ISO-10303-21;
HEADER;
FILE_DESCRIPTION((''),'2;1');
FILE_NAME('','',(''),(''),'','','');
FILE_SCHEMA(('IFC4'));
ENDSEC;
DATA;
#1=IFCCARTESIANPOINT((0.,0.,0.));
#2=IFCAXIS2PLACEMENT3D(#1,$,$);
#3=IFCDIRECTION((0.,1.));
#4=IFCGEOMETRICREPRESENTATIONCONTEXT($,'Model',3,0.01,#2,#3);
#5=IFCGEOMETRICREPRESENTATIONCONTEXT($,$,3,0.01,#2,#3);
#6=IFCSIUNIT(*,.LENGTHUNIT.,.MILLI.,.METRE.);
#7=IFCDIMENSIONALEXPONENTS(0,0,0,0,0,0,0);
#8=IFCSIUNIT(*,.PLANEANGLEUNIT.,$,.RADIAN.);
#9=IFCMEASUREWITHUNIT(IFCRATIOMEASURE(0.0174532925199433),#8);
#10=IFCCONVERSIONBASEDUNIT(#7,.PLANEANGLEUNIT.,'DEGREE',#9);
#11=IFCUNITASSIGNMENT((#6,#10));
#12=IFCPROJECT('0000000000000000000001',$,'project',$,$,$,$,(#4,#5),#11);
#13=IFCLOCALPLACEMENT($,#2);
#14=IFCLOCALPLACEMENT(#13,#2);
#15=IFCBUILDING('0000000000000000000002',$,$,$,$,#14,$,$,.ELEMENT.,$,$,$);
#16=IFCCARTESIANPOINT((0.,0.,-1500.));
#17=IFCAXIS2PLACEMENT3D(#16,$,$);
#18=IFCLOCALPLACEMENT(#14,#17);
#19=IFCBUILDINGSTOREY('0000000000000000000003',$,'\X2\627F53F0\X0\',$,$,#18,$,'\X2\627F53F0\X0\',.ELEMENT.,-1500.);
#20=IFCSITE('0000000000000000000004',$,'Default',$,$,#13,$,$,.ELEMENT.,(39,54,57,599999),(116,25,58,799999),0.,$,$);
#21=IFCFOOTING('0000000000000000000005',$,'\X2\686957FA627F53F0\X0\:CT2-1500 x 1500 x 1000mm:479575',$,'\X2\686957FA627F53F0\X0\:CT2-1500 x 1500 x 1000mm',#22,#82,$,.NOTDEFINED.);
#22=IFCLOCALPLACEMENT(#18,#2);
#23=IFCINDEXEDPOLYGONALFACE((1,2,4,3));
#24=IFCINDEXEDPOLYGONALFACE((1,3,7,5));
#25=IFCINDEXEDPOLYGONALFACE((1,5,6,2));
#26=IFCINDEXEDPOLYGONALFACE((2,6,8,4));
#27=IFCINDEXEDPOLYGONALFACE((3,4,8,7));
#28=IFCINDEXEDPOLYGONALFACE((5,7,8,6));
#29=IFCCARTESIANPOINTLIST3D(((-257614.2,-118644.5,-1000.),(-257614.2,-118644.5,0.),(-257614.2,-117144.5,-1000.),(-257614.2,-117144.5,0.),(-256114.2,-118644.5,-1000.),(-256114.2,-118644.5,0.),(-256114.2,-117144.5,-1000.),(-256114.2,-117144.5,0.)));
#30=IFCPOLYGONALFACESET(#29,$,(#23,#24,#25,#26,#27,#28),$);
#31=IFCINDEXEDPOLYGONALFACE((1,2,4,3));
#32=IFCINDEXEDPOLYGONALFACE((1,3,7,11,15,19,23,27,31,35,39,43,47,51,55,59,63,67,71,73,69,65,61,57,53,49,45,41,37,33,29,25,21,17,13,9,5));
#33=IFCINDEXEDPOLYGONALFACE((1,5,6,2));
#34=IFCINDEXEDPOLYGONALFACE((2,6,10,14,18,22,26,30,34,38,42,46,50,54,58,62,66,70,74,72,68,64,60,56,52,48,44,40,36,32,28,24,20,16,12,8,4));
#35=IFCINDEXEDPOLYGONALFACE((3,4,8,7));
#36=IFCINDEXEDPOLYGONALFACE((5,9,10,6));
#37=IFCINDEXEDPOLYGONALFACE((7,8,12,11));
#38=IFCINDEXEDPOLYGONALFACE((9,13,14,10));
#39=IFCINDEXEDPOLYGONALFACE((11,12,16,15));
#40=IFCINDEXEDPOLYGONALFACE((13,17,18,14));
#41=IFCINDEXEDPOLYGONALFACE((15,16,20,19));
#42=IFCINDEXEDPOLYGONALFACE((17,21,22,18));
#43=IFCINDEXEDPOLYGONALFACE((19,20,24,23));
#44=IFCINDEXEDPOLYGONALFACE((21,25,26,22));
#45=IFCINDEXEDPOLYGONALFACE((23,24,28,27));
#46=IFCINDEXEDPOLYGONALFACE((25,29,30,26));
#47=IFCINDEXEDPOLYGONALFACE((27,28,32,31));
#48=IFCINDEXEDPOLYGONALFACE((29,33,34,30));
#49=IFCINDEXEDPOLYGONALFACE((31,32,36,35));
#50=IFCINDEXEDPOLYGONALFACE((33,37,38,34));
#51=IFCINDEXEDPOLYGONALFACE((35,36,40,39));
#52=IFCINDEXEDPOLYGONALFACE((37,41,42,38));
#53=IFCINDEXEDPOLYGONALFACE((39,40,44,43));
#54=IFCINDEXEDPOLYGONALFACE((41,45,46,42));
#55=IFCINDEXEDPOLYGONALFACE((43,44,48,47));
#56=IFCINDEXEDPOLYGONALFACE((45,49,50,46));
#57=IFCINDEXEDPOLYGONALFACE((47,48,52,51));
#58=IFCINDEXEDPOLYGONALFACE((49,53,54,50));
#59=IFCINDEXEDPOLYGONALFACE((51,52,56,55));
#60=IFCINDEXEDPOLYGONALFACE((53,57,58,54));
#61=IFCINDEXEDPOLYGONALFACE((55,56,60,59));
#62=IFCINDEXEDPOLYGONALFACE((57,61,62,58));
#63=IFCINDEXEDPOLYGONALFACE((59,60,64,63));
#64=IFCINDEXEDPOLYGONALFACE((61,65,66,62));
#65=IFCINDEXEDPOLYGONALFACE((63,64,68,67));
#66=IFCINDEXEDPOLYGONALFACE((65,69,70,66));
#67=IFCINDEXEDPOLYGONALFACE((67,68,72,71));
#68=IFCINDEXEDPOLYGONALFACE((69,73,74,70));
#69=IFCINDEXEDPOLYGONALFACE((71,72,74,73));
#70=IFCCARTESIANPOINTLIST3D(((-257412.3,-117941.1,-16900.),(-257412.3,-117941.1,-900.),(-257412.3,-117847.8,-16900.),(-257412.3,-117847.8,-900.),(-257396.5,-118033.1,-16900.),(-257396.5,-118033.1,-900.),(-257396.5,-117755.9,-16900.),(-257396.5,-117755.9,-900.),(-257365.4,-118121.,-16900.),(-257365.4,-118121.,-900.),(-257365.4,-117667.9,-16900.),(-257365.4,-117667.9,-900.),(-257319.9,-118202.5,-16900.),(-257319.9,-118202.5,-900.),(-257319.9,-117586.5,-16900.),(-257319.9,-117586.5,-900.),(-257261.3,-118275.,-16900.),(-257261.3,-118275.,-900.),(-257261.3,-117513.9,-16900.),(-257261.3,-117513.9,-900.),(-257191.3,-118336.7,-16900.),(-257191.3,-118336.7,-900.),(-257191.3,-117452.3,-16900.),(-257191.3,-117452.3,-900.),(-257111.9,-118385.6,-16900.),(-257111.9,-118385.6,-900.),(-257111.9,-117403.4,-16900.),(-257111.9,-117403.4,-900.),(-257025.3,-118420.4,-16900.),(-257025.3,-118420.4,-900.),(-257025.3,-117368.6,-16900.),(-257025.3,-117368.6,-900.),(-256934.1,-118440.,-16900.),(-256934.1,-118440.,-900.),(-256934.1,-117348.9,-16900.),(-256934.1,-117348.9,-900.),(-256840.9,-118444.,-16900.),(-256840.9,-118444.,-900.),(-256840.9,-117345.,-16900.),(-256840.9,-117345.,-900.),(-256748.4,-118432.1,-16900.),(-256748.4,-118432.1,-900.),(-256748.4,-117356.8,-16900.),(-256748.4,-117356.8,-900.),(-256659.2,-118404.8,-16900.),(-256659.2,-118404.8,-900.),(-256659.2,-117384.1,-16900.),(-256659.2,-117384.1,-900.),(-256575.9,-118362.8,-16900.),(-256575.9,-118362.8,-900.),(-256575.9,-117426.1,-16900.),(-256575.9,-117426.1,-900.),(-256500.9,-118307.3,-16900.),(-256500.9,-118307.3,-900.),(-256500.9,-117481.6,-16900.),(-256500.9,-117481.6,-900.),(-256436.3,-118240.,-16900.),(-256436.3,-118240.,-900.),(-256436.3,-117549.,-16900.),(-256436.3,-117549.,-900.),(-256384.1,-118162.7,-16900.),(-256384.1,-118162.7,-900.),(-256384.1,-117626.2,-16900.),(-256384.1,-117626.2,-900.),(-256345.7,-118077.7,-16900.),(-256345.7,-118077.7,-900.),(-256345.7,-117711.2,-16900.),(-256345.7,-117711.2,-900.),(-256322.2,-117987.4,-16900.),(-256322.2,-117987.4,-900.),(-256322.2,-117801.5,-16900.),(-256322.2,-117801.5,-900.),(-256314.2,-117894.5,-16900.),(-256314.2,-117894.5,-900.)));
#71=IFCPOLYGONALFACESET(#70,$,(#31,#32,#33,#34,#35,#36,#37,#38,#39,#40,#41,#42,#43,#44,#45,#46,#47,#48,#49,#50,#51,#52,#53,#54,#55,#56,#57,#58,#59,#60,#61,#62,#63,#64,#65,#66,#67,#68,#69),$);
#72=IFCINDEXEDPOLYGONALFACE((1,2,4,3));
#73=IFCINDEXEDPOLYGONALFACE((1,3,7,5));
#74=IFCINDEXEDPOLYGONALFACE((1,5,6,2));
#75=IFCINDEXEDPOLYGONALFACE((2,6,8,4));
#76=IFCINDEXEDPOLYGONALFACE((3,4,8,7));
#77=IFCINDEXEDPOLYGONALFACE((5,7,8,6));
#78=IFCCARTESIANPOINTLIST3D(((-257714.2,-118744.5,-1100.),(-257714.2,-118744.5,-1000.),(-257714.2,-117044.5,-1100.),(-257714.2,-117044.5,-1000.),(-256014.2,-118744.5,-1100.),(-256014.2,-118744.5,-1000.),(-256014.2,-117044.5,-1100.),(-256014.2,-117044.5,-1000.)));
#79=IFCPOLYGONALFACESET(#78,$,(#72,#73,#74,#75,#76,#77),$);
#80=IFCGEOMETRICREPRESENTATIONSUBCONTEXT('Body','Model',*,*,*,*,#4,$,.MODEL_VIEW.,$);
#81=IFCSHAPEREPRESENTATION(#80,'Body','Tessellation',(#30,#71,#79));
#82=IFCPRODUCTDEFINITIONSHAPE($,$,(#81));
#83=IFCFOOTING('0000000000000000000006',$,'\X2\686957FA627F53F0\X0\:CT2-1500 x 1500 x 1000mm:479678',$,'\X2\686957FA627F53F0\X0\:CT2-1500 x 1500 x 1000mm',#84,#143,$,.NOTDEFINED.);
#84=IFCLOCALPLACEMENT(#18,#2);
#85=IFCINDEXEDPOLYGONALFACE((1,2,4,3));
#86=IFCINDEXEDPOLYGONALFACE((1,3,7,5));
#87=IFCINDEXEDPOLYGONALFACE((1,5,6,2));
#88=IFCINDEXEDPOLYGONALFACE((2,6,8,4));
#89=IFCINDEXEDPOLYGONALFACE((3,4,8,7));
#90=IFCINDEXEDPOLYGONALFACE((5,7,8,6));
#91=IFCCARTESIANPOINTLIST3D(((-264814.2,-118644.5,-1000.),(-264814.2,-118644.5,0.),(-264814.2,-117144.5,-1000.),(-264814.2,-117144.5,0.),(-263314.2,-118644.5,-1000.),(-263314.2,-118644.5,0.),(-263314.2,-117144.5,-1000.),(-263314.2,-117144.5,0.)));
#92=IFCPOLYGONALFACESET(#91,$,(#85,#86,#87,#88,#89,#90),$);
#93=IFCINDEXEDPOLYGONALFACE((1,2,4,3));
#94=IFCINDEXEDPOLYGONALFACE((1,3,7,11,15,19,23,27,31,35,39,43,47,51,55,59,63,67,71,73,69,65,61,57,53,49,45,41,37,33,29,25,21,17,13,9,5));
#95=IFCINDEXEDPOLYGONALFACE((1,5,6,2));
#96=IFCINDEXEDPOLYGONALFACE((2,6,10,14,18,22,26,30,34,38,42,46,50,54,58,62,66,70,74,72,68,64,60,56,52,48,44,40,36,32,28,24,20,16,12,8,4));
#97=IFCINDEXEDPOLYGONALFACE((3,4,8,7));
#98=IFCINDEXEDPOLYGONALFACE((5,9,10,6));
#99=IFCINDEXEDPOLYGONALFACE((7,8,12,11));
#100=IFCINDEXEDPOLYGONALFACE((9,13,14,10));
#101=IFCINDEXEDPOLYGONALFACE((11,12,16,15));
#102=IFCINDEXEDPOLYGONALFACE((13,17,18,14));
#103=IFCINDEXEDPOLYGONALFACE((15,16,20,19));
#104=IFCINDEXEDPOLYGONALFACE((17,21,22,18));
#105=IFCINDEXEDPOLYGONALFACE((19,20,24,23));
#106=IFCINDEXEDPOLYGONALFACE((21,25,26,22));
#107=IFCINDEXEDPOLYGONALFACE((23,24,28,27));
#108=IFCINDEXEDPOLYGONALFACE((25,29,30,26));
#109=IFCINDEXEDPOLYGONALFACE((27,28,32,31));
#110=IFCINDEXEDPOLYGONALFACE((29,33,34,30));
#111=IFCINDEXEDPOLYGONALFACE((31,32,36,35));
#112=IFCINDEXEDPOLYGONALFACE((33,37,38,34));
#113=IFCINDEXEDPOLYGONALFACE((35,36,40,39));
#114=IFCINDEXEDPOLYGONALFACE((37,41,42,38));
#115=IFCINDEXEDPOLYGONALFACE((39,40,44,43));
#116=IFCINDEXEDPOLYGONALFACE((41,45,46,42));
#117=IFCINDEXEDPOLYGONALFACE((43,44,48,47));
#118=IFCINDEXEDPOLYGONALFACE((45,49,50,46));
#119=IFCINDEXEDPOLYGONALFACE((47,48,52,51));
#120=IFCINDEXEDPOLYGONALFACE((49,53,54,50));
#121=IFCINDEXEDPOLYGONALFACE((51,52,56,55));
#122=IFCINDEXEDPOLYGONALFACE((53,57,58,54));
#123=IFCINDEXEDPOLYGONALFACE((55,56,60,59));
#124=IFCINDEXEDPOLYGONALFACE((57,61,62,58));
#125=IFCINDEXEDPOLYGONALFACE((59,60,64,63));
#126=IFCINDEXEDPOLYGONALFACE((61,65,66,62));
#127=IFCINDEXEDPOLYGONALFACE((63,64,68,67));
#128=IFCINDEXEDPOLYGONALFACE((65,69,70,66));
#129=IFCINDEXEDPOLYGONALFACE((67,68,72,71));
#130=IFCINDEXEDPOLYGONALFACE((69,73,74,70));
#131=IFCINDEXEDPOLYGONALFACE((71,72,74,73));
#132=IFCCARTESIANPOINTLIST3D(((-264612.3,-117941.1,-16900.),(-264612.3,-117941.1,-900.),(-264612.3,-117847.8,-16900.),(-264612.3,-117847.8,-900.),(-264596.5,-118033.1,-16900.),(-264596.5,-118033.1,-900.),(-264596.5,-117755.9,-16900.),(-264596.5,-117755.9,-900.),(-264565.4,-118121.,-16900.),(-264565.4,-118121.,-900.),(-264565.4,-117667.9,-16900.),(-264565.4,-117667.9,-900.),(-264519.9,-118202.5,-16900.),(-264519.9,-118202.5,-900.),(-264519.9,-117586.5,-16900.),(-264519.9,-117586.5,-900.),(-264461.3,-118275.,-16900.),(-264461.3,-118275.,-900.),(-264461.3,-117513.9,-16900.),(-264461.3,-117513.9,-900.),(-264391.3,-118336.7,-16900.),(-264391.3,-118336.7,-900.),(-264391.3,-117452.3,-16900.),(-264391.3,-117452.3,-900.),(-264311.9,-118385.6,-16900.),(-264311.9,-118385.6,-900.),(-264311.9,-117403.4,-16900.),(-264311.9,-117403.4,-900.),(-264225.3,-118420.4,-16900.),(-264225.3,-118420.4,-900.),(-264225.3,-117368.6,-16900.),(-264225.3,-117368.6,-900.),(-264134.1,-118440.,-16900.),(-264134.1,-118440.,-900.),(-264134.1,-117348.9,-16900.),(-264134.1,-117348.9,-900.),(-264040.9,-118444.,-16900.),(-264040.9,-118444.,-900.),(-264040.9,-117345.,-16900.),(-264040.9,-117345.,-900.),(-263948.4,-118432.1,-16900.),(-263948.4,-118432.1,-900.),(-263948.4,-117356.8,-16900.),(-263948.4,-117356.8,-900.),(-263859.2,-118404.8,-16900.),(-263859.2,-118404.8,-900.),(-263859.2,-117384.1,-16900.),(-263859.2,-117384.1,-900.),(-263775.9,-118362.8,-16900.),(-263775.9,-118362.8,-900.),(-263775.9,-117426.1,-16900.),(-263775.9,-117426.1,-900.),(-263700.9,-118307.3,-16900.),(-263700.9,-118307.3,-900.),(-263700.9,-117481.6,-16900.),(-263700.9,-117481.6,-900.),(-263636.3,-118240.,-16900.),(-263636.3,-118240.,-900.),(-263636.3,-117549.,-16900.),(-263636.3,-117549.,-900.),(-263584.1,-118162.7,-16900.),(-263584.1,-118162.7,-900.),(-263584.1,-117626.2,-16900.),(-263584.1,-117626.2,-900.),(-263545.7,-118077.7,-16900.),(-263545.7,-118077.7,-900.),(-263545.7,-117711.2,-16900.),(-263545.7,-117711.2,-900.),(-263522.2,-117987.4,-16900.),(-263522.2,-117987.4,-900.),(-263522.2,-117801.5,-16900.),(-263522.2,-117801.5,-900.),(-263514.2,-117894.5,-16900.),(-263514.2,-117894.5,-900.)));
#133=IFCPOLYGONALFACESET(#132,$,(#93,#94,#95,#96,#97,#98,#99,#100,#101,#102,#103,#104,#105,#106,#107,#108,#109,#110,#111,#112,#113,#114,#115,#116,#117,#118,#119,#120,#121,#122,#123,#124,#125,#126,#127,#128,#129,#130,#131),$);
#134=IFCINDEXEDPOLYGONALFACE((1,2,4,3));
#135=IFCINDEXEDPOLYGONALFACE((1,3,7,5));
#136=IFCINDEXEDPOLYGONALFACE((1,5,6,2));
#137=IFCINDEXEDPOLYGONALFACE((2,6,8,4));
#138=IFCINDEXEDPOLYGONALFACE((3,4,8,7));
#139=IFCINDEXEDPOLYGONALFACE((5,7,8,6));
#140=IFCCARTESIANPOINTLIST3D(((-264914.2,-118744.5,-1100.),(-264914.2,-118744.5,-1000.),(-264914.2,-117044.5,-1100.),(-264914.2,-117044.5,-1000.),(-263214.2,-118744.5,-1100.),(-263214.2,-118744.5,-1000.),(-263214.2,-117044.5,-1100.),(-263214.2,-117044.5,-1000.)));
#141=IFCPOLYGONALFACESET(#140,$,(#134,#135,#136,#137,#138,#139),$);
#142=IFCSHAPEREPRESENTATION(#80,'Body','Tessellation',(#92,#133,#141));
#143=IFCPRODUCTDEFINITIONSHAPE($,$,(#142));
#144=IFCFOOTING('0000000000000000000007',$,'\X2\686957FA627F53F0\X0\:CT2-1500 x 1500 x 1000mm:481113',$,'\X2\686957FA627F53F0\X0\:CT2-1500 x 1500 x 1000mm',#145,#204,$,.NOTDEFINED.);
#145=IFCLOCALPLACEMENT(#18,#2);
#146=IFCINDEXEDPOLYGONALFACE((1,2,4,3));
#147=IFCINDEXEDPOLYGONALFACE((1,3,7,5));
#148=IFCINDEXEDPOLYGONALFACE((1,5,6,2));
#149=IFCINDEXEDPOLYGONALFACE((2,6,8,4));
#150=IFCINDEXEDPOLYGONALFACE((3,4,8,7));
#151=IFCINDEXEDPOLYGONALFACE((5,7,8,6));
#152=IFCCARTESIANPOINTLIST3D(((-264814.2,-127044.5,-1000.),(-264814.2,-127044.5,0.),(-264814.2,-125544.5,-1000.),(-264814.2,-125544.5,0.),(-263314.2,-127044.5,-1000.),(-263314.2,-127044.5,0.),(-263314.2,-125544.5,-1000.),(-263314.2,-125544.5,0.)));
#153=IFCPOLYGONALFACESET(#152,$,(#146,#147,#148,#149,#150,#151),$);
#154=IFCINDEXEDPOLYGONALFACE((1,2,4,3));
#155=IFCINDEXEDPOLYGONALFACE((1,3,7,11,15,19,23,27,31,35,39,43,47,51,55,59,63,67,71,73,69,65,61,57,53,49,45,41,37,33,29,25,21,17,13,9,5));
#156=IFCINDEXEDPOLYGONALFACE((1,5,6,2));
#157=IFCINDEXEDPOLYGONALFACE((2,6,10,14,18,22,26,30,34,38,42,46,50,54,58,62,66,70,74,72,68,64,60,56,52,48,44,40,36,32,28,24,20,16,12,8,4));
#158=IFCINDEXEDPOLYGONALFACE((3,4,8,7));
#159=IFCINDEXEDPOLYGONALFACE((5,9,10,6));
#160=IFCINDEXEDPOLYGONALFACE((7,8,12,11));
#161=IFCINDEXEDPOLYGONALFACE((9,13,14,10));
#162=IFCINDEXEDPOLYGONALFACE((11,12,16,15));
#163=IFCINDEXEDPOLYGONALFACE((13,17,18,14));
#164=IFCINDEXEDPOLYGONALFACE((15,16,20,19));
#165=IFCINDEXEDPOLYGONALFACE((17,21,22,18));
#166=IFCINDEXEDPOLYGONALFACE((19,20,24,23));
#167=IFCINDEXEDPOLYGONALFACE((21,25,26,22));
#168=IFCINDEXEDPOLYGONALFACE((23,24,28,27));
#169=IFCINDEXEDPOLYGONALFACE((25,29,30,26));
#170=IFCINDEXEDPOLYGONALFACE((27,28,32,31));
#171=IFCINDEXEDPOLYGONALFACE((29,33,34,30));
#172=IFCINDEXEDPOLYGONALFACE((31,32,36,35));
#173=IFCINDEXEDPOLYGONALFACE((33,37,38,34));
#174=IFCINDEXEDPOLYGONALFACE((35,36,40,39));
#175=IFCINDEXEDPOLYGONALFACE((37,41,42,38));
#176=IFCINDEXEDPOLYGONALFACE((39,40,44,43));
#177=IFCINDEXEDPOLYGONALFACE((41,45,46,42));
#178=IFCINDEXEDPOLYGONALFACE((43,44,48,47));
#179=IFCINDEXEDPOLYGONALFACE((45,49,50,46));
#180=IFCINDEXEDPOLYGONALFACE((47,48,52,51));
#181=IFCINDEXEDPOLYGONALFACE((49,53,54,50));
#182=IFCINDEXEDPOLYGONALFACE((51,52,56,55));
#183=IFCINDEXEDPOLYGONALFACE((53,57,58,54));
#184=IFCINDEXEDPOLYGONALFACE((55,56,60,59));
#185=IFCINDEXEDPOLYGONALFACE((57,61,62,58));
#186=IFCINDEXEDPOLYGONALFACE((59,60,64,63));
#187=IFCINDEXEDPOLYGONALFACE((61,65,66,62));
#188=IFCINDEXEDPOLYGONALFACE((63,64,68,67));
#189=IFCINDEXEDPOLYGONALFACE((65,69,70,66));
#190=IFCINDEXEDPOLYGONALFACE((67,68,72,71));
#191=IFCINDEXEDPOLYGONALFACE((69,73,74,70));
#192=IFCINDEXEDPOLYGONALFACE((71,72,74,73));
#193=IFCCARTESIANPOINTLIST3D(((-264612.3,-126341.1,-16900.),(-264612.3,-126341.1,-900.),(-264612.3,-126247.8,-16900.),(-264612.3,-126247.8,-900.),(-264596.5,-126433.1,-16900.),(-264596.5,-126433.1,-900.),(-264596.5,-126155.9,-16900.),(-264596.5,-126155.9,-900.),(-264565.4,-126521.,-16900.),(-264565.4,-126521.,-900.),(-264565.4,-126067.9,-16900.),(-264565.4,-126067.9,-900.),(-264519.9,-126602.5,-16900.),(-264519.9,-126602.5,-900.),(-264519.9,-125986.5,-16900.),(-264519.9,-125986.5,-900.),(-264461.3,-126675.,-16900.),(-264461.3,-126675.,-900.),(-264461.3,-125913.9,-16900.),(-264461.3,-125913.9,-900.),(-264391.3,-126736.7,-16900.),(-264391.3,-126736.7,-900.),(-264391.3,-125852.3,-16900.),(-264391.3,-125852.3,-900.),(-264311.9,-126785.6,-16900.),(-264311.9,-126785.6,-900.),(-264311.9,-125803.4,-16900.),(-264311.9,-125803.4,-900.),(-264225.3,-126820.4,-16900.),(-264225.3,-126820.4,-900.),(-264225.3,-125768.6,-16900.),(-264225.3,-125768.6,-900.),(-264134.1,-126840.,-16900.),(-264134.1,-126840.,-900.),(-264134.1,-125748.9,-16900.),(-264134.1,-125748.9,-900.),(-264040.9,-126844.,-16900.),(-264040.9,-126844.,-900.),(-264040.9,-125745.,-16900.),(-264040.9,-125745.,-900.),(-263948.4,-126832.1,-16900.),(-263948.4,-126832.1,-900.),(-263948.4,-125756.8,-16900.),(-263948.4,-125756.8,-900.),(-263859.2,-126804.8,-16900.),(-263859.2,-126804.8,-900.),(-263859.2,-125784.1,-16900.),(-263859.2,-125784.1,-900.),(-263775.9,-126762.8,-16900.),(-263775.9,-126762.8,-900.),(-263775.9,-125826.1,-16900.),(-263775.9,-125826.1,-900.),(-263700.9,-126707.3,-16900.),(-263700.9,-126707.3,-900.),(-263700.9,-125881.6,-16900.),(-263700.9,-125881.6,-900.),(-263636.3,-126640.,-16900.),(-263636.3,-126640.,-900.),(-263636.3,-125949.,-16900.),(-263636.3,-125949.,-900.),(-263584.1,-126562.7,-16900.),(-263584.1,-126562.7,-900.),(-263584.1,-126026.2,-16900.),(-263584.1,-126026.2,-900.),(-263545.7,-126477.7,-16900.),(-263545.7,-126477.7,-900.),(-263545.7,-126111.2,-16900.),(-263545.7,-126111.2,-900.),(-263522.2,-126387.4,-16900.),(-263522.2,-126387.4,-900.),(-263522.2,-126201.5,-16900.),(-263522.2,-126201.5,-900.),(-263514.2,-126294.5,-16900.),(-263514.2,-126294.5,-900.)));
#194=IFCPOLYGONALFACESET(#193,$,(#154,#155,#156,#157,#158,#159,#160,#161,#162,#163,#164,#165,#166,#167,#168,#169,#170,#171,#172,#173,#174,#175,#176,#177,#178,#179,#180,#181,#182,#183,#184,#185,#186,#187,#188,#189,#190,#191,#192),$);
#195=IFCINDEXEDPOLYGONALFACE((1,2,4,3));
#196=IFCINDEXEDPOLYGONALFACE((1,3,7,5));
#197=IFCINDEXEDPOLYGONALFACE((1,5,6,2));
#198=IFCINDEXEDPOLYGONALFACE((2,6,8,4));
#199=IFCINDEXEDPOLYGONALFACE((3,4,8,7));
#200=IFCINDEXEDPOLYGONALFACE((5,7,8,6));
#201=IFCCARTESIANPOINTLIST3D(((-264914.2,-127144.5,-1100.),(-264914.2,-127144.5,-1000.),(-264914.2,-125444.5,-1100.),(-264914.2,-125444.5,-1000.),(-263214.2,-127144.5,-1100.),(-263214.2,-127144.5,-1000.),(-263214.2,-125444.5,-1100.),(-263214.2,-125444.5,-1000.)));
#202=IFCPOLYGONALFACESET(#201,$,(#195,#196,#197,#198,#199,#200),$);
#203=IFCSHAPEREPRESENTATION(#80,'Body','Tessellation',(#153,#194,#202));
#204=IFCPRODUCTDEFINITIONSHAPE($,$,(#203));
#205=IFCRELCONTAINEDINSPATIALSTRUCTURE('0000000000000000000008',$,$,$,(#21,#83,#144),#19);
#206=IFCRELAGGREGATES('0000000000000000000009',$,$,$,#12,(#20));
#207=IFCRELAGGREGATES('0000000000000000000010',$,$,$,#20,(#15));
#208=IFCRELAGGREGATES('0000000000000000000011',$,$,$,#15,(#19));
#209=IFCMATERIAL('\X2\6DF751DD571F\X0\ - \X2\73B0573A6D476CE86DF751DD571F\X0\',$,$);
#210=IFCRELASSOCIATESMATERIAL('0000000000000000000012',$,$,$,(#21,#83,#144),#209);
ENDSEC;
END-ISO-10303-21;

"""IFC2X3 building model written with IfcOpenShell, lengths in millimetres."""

from ifc_helpers import new_model, entity, si_unit, converted_unit, direction, frame, frame_2d, origin, origin_2d_with_axis, place, context, subcontext, project, spatial, rectangle, circle, extrude, material, element, save


model = new_model("IFC2X3")

# Units and contexts
model_context = context("Model", 3, precision=0.01, world=origin(), true_north=direction((0.0, 1.0)))
context_of_model = context(None, 3, precision=0.01, world=origin(), true_north=direction((0.0, 1.0)))
body_context = subcontext(model_context, "Body", "Model", "MODEL_VIEW")
ifc_project = project(units=[si_unit("LENGTHUNIT", "METRE", prefix="MILLI"), converted_unit("PLANEANGLEUNIT", "DEGREE", entity("IfcRatioMeasure", 0.0174532925199433), si_unit("PLANEANGLEUNIT", "RADIAN"), dimensions=[0, 0, 0, 0, 0, 0, 0])], contexts=[model_context, context_of_model])

# Site, building, storey
site_placement = place(None, origin())
site = spatial("IfcSite", under=ifc_project, at=site_placement, Name="Default", CompositionType="ELEMENT", RefLatitude=(39, 54, 57, 599999), RefLongitude=(116, 25, 58, 799999), RefElevation=0.0)
building_placement = place(site_placement, origin())
building = spatial("IfcBuilding", under=site, at=building_placement, CompositionType="ELEMENT")
storey_placement = place(building_placement, frame((0.0, 0.0, -1500.0)))
storey = spatial("IfcBuildingStorey", under=building, at=storey_placement, Name="承台", LongName="承台", CompositionType="ELEMENT", Elevation=-1500.0)

# Footings
ifc_material_1 = material(Name="混凝土 - 现场浇注混凝土")
footing_1_placement = place(storey_placement, frame((-257714.2, -118744.5, -16900.0)))
element("IfcFooting", 1, at=footing_1_placement, inside=storey, material=ifc_material_1, Name="桩基承台:CT2-1500 x 1500 x 1000mm:479575", ObjectType="桩基承台:CT2-1500 x 1500 x 1000mm", PredefinedType="NOTDEFINED", context=body_context, shape_type="SweptSolid", body=[
    extrude(rectangle(XDim=1500.0, YDim=1500.0, at=origin_2d_with_axis()), frame((850.0, 850.0, 15900.0), z_axis=(0.0, 0.0, 1.0), x_axis=(-1.0, 0.0, 0.0)), (0.0, 0.0, 1.0), 1000.0),
    extrude(circle(Radius=550.0, at=origin_2d_with_axis()), frame((850.0, 850.0, 0.0)), (0.0, 0.0, 1.0), 16000.0),
    extrude(rectangle(XDim=1700.0, YDim=1700.0, at=frame_2d((0.0, 0.0), x_axis=(1.0, 0.0))), frame((850.0, 850.0, 15800.0), z_axis=(0.0, 0.0, 1.0), x_axis=(0.0, 1.0, 0.0)), (0.0, 0.0, 1.0), 100.0),
])
footing_2_placement = place(storey_placement, frame((-264914.2, -118744.5, -16900.0)))
element("IfcFooting", 2, at=footing_2_placement, inside=storey, material=ifc_material_1, Name="桩基承台:CT2-1500 x 1500 x 1000mm:479678", ObjectType="桩基承台:CT2-1500 x 1500 x 1000mm", PredefinedType="NOTDEFINED", context=body_context, shape_type="SweptSolid", body=[
    extrude(rectangle(XDim=1500.0, YDim=1500.0, at=origin_2d_with_axis()), frame((850.0, 850.0, 15900.0), z_axis=(0.0, 0.0, 1.0), x_axis=(-1.0, 0.0, 0.0)), (0.0, 0.0, 1.0), 1000.0),
    extrude(circle(Radius=550.0, at=origin_2d_with_axis()), frame((850.0, 850.0, 0.0)), (0.0, 0.0, 1.0), 16000.0),
    extrude(rectangle(XDim=1700.0, YDim=1700.0, at=frame_2d((0.0, 0.0), x_axis=(1.0, 0.0))), frame((850.0, 850.0, 15800.0), z_axis=(0.0, 0.0, 1.0), x_axis=(0.0, 1.0, 0.0)), (0.0, 0.0, 1.0), 100.0),
])
footing_3_placement = place(storey_placement, frame((-264914.2, -127144.5, -16900.0)))
element("IfcFooting", 3, at=footing_3_placement, inside=storey, material=ifc_material_1, Name="桩基承台:CT2-1500 x 1500 x 1000mm:481113", ObjectType="桩基承台:CT2-1500 x 1500 x 1000mm", PredefinedType="NOTDEFINED", context=body_context, shape_type="SweptSolid", body=[
    extrude(rectangle(XDim=1500.0, YDim=1500.0, at=origin_2d_with_axis()), frame((850.0, 850.0, 15900.0), z_axis=(0.0, 0.0, 1.0), x_axis=(-1.0, 0.0, 0.0)), (0.0, 0.0, 1.0), 1000.0),
    extrude(circle(Radius=550.0, at=origin_2d_with_axis()), frame((850.0, 850.0, 0.0)), (0.0, 0.0, 1.0), 16000.0),
    extrude(rectangle(XDim=1700.0, YDim=1700.0, at=frame_2d((0.0, 0.0), x_axis=(1.0, 0.0))), frame((850.0, 850.0, 15800.0), z_axis=(0.0, 0.0, 1.0), x_axis=(0.0, 1.0, 0.0)), (0.0, 0.0, 1.0), 100.0),
])

save(model, "model.ifc")
